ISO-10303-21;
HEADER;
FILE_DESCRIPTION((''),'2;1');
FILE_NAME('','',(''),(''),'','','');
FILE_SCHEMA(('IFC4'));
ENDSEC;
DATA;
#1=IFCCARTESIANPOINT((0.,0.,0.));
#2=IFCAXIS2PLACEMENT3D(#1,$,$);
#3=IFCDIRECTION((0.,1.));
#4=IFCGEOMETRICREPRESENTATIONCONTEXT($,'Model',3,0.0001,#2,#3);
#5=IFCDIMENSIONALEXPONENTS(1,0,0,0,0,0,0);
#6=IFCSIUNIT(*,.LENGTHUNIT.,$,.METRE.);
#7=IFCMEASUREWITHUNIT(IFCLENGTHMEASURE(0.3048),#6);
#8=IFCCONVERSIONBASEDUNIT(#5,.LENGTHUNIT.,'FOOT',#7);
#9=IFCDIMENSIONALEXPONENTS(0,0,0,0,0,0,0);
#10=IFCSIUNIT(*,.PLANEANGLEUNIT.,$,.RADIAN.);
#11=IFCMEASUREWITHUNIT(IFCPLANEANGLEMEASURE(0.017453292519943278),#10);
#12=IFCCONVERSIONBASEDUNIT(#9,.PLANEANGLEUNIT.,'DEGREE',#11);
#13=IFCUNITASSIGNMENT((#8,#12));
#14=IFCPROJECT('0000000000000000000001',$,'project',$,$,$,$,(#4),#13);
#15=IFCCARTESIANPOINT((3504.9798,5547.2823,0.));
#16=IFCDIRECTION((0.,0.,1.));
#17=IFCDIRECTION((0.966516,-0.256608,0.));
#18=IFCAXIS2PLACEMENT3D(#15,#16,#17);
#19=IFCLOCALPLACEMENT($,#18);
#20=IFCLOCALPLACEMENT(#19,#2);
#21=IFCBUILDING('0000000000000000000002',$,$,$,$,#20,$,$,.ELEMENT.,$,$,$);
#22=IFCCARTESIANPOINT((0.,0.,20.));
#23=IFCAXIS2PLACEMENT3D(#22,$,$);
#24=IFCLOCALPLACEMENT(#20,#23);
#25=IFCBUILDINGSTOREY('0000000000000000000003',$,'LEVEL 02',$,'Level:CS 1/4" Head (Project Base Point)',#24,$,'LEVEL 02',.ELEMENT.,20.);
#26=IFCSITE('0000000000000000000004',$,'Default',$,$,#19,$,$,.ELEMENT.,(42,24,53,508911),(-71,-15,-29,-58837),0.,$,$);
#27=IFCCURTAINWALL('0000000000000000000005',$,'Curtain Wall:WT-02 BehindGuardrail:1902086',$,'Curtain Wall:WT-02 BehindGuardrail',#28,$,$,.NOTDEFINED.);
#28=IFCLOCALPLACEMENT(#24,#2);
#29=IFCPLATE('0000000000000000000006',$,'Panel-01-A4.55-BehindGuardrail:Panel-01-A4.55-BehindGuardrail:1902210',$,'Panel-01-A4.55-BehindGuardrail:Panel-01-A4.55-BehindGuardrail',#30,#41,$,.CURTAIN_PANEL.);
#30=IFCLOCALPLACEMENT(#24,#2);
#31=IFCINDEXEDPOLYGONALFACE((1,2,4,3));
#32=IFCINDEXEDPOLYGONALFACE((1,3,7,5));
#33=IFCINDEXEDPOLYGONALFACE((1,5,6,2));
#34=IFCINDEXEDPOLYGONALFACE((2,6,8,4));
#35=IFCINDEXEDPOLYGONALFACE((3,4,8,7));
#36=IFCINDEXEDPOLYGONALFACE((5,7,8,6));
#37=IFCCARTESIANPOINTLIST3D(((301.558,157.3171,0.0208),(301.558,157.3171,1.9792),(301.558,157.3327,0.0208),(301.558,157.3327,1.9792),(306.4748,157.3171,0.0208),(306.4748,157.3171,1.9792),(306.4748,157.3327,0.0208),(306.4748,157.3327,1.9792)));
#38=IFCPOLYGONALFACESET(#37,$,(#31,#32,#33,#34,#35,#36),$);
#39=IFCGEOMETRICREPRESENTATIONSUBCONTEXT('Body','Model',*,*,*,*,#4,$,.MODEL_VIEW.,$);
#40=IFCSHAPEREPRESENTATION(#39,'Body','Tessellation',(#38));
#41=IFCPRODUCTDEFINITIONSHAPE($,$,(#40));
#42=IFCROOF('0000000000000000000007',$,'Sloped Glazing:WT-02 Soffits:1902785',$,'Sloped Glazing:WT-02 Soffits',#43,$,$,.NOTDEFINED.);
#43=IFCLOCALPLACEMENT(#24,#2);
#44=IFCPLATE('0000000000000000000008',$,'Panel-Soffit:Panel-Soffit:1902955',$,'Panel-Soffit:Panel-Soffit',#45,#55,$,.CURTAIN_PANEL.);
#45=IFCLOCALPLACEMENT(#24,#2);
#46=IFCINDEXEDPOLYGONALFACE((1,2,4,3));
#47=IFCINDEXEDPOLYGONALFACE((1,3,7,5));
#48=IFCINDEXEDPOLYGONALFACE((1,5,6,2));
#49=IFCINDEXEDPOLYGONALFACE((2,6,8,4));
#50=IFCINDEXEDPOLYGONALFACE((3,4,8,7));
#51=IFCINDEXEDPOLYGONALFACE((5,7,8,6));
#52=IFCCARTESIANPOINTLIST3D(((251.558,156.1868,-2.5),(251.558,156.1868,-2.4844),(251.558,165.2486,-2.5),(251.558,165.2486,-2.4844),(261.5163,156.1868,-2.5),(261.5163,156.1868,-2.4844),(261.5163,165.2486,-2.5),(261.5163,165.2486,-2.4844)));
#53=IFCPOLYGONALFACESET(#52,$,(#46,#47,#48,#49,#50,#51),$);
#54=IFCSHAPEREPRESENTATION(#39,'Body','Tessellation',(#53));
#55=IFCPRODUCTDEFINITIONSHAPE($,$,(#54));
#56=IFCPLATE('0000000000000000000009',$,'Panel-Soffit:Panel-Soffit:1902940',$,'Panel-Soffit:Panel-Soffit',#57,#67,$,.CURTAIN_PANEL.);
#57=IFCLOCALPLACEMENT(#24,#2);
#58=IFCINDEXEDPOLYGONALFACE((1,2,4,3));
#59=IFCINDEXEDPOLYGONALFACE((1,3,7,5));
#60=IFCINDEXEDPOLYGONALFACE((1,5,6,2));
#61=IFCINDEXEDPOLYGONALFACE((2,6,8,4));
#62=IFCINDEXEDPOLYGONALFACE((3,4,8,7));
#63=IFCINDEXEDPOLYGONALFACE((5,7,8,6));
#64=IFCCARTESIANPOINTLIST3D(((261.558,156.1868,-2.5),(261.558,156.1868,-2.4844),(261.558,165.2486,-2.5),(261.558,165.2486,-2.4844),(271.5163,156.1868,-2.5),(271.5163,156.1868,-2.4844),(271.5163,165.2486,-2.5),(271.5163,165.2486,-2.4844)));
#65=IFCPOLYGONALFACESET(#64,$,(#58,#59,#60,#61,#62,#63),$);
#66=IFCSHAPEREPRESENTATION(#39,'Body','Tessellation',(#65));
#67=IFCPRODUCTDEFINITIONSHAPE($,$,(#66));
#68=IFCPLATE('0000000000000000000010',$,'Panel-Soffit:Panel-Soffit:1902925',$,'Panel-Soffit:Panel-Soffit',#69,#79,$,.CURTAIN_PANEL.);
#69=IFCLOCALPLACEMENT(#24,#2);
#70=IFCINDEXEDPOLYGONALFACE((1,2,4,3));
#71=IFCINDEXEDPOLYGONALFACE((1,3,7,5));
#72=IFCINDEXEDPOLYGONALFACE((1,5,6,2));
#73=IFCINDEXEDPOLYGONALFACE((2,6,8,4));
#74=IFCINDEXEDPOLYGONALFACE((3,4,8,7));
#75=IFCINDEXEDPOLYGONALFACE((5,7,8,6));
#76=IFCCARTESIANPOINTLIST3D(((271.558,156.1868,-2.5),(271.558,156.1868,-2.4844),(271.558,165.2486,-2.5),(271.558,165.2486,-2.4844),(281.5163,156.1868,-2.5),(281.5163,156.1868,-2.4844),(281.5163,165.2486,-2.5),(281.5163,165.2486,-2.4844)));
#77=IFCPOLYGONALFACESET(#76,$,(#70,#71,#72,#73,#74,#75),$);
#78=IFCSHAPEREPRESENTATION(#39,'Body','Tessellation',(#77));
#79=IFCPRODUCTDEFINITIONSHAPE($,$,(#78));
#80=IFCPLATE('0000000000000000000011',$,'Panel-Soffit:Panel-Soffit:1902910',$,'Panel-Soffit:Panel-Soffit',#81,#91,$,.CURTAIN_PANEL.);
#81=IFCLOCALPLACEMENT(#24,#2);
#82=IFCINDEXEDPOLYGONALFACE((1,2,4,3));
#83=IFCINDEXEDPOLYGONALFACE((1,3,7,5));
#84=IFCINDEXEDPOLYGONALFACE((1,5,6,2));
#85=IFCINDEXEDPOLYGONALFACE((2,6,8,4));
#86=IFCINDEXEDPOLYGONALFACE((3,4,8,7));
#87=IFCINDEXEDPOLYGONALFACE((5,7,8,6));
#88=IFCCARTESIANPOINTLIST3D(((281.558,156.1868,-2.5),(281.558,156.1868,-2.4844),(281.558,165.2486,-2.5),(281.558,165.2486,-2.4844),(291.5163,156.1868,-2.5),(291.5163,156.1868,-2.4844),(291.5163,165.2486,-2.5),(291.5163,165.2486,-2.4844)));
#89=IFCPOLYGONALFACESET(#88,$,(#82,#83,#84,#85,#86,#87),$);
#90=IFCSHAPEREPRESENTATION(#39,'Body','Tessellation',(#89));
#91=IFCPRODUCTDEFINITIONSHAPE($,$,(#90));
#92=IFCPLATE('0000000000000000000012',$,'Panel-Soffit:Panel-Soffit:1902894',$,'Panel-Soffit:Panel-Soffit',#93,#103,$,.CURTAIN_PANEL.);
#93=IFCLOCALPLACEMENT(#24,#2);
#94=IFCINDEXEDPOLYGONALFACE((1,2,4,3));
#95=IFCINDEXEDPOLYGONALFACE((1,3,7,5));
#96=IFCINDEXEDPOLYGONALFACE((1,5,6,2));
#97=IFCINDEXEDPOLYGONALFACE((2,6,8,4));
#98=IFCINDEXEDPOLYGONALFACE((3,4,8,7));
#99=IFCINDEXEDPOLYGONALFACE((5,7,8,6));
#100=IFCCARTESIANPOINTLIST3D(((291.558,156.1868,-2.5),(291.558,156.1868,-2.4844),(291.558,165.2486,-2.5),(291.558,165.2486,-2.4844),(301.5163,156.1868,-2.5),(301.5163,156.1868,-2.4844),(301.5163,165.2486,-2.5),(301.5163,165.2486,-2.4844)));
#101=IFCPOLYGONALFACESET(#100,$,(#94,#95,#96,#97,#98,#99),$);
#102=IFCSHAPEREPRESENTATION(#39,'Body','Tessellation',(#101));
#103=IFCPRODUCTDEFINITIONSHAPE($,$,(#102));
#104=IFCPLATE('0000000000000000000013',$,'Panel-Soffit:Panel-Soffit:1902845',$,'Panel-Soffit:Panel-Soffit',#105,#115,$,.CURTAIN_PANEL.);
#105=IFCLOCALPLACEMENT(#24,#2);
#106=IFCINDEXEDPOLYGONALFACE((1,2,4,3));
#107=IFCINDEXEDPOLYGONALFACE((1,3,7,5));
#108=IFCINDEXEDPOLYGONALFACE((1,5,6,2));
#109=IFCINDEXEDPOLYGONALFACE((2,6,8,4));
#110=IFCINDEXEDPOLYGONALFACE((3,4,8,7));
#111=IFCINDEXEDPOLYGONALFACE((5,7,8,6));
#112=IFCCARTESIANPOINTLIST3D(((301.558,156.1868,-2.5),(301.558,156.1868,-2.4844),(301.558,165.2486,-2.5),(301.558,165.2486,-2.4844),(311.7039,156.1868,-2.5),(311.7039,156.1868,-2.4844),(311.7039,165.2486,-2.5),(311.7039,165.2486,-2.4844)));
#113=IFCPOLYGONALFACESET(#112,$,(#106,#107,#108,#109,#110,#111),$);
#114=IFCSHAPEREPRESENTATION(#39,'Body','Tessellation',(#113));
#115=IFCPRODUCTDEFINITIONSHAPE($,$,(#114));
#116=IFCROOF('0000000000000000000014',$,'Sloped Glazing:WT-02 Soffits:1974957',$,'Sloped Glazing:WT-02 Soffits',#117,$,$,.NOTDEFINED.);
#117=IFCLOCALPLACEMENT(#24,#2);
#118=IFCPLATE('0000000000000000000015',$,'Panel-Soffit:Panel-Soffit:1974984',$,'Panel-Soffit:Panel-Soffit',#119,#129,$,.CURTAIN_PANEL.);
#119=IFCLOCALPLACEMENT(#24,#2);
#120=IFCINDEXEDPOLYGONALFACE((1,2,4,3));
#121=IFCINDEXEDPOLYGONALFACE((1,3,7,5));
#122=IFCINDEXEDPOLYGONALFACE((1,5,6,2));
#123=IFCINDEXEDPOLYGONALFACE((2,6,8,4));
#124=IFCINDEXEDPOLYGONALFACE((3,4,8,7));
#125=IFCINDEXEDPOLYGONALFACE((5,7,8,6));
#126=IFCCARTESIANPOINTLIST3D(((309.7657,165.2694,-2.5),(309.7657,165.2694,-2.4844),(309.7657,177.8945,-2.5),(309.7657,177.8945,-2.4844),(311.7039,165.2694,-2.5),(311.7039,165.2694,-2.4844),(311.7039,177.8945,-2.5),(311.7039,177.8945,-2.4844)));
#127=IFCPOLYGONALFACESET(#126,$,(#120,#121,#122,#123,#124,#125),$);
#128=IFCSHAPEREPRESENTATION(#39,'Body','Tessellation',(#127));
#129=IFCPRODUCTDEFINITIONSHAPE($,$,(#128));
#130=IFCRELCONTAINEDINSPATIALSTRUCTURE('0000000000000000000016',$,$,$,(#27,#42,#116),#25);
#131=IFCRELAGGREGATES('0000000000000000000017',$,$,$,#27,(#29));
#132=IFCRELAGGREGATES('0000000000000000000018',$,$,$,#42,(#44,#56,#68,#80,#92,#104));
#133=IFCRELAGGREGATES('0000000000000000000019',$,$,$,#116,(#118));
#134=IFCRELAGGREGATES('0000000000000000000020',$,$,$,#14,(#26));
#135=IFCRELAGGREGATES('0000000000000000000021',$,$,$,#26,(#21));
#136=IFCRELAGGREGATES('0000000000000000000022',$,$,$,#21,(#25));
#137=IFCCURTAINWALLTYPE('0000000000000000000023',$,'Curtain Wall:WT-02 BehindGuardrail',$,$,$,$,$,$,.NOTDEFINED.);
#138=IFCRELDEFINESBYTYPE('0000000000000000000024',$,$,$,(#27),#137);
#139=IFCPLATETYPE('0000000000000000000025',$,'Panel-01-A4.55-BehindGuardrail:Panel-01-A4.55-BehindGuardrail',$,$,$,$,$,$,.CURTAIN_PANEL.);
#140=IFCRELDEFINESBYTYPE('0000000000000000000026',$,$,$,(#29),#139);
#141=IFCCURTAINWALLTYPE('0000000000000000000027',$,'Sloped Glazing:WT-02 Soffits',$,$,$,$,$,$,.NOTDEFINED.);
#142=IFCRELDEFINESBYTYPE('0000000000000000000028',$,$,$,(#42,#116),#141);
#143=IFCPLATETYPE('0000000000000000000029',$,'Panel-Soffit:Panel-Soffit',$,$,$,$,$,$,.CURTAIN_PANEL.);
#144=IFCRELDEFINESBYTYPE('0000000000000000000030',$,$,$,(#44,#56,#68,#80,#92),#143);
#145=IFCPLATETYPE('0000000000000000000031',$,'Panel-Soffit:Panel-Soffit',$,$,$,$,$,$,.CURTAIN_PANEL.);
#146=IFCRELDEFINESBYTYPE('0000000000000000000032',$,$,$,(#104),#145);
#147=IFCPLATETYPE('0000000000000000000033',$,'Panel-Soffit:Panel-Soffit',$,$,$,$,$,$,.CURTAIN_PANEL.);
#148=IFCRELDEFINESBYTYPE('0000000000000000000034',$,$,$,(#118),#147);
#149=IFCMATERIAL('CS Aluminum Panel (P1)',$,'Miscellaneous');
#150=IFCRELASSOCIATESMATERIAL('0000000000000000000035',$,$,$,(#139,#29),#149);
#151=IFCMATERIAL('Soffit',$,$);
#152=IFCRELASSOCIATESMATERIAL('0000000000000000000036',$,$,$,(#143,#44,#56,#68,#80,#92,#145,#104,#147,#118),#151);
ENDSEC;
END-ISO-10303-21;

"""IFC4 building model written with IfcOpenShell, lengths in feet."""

from ifc_helpers import new_model, entity, si_unit, converted_unit, direction, frame, origin, place, context, subcontext, project, spatial, indexed_curve, outline, extrude, source, transform, mapped, material, type_object, type_shapes, element, aggregate, save


model = new_model("IFC4")

# Units and contexts
model_context = context("Model", 3, precision=0.0001, world=origin(), true_north=direction((0.0, 1.0)))
body_context = subcontext(model_context, "Body", "Model", "MODEL_VIEW")
ifc_project = project(units=[converted_unit("LENGTHUNIT", "FOOT", entity("IfcLengthMeasure", 0.3048), si_unit("LENGTHUNIT", "METRE"), dimensions=[1, 0, 0, 0, 0, 0, 0]), converted_unit("PLANEANGLEUNIT", "DEGREE", entity("IfcPlaneAngleMeasure", 0.017453292519943278), si_unit("PLANEANGLEUNIT", "RADIAN"), dimensions=[0, 0, 0, 0, 0, 0, 0])], contexts=[model_context])

# Site, building, storey
site_placement = place(None, frame((3504.9798, 5547.2823, 0.0), z_axis=(0.0, 0.0, 1.0), x_axis=(0.966516, -0.256608, 0.0)))
site = spatial("IfcSite", under=ifc_project, at=site_placement, Name="Default", CompositionType="ELEMENT", RefLatitude=(42, 24, 53, 508911), RefLongitude=(-71, -15, -29, -58837), RefElevation=0.0)
building_placement = place(site_placement, origin())
building = spatial("IfcBuilding", under=site, at=building_placement, CompositionType="ELEMENT")
storey_placement = place(building_placement, frame((0.0, 0.0, 20.0)))
storey = spatial("IfcBuildingStorey", under=building, at=storey_placement, Name="LEVEL 02", ObjectType="Level:CS 1/4\" Head (Project Base Point)", LongName="LEVEL 02", CompositionType="ELEMENT", Elevation=20.0)

# Curtain wall, plate
ifc_material_1 = material(Name="CS Aluminum Panel (P1)", Category="Miscellaneous")
curtain_wall_type_1 = type_object("IfcCurtainWallType", Name="Curtain Wall:WT-02 BehindGuardrail", PredefinedType="NOTDEFINED")
curtain_wall_1_placement = place(storey_placement, frame((0.0, 0.0, -20.0)))
curtain_wall_1 = element("IfcCurtainWall", 1, at=curtain_wall_1_placement, inside=storey, type_object=curtain_wall_type_1, Name="Curtain Wall:WT-02 BehindGuardrail:1902086", ObjectType="Curtain Wall:WT-02 BehindGuardrail", PredefinedType="NOTDEFINED")
plate_type_1 = type_object("IfcPlateType", Name="Panel-01-A4.55-BehindGuardrail:Panel-01-A4.55-BehindGuardrail", PredefinedType="CURTAIN_PANEL", material=ifc_material_1)
shared_shape_1 = source(origin(), body_context, "Body", "SweptSolid", [
    extrude(outline(indexed_curve([(-0.0078, -2.4584), (0.0078, -2.4584), (0.0078, 2.4584), (-0.0078, 2.4584), (-0.0078, -2.4584)], self_intersect=False)), frame((2.4584, 0.0078, 0.0), z_axis=(0.0, 0.0, 1.0), x_axis=(0.0, -1.0, 0.0)), (0.0, 0.0, 1.0), 1.9583),
])
type_shapes(plate_type_1, [shared_shape_1])
plate_1_placement = place(curtain_wall_1_placement, frame((301.558, 157.3171, 20.0208)))
plate_1 = element("IfcPlate", 2, at=plate_1_placement, type_object=plate_type_1, material=ifc_material_1, Name="Panel-01-A4.55-BehindGuardrail:Panel-01-A4.55-BehindGuardrail:1902210", ObjectType="Panel-01-A4.55-BehindGuardrail:Panel-01-A4.55-BehindGuardrail", PredefinedType="CURTAIN_PANEL", context=body_context, shape_type="MappedRepresentation", body=[
    mapped(shared_shape_1, transform((0.0, 0.0, 0.0), scale=1.0)),
])
aggregate(curtain_wall_1, [plate_1])

# Roof, plates
curtain_wall_type_2 = type_object("IfcCurtainWallType", Name="Sloped Glazing:WT-02 Soffits", PredefinedType="NOTDEFINED")
roof_1_placement = place(storey_placement, frame((0.0, 0.0, -20.0)))
roof_1 = element("IfcRoof", 3, at=roof_1_placement, inside=storey, type_object=curtain_wall_type_2, Name="Sloped Glazing:WT-02 Soffits:1902785", ObjectType="Sloped Glazing:WT-02 Soffits", PredefinedType="NOTDEFINED")
ifc_material_2 = material(Name="Soffit")
plate_type_2 = type_object("IfcPlateType", Name="Panel-Soffit:Panel-Soffit", PredefinedType="CURTAIN_PANEL", material=ifc_material_2)
shared_shape_2 = source(origin(), body_context, "Body", "SweptSolid", [
    extrude(outline(indexed_curve([(-0.0078, -4.9792), (0.0078, -4.9792), (0.0078, 4.9792), (-0.0078, 4.9792), (-0.0078, -4.9792)], self_intersect=False)), frame((4.9792, 0.0078, 0.0), z_axis=(0.0, 0.0, 1.0), x_axis=(0.0, -1.0, 0.0)), (0.0, 0.0, 1.0), 9.0617),
])
type_shapes(plate_type_2, [shared_shape_2])
plate_2_placement = place(roof_1_placement, frame((251.558, 156.1868, 17.5156), z_axis=(0.0, 1.0, 0.0), x_axis=(1.0, 0.0, 0.0)))
plate_2 = element("IfcPlate", 4, at=plate_2_placement, type_object=plate_type_2, material=ifc_material_2, Name="Panel-Soffit:Panel-Soffit:1902955", ObjectType="Panel-Soffit:Panel-Soffit", PredefinedType="CURTAIN_PANEL", context=body_context, shape_type="MappedRepresentation", body=[
    mapped(shared_shape_2, transform((0.0, 0.0, 0.0), scale=1.0)),
])
plate_3_placement = place(roof_1_placement, frame((261.558, 156.1868, 17.5156), z_axis=(0.0, 1.0, 0.0), x_axis=(1.0, 0.0, 0.0)))
plate_3 = element("IfcPlate", 5, at=plate_3_placement, type_object=plate_type_2, material=ifc_material_2, Name="Panel-Soffit:Panel-Soffit:1902940", ObjectType="Panel-Soffit:Panel-Soffit", PredefinedType="CURTAIN_PANEL", context=body_context, shape_type="MappedRepresentation", body=[
    mapped(shared_shape_2, transform((0.0, 0.0, 0.0), scale=1.0)),
])
plate_4_placement = place(roof_1_placement, frame((271.558, 156.1868, 17.5156), z_axis=(0.0, 1.0, 0.0), x_axis=(1.0, 0.0, 0.0)))
plate_4 = element("IfcPlate", 6, at=plate_4_placement, type_object=plate_type_2, material=ifc_material_2, Name="Panel-Soffit:Panel-Soffit:1902925", ObjectType="Panel-Soffit:Panel-Soffit", PredefinedType="CURTAIN_PANEL", context=body_context, shape_type="MappedRepresentation", body=[
    mapped(shared_shape_2, transform((0.0, 0.0, 0.0), scale=1.0)),
])
plate_5_placement = place(roof_1_placement, frame((281.558, 156.1868, 17.5156), z_axis=(0.0, 1.0, 0.0), x_axis=(1.0, 0.0, 0.0)))
plate_5 = element("IfcPlate", 7, at=plate_5_placement, type_object=plate_type_2, material=ifc_material_2, Name="Panel-Soffit:Panel-Soffit:1902910", ObjectType="Panel-Soffit:Panel-Soffit", PredefinedType="CURTAIN_PANEL", context=body_context, shape_type="MappedRepresentation", body=[
    mapped(shared_shape_2, transform((0.0, 0.0, 0.0), scale=1.0)),
])
plate_6_placement = place(roof_1_placement, frame((291.558, 156.1868, 17.5156), z_axis=(0.0, 1.0, 0.0), x_axis=(1.0, 0.0, 0.0)))
plate_6 = element("IfcPlate", 8, at=plate_6_placement, type_object=plate_type_2, material=ifc_material_2, Name="Panel-Soffit:Panel-Soffit:1902894", ObjectType="Panel-Soffit:Panel-Soffit", PredefinedType="CURTAIN_PANEL", context=body_context, shape_type="MappedRepresentation", body=[
    mapped(shared_shape_2, transform((0.0, 0.0, 0.0), scale=1.0)),
])
plate_type_3 = type_object("IfcPlateType", Name="Panel-Soffit:Panel-Soffit", PredefinedType="CURTAIN_PANEL", material=ifc_material_2)
shared_shape_3 = source(origin(), body_context, "Body", "SweptSolid", [
    extrude(outline(indexed_curve([(-0.0078, -5.073), (0.0078, -5.073), (0.0078, 5.073), (-0.0078, 5.073), (-0.0078, -5.073)], self_intersect=False)), frame((5.073, 0.0078, 0.0), z_axis=(0.0, 0.0, 1.0), x_axis=(0.0, -1.0, 0.0)), (0.0, 0.0, 1.0), 9.0617),
])
type_shapes(plate_type_3, [shared_shape_3])
plate_7_placement = place(roof_1_placement, frame((301.558, 156.1868, 17.5156), z_axis=(0.0, 1.0, 0.0), x_axis=(1.0, 0.0, 0.0)))
plate_7 = element("IfcPlate", 9, at=plate_7_placement, type_object=plate_type_3, material=ifc_material_2, Name="Panel-Soffit:Panel-Soffit:1902845", ObjectType="Panel-Soffit:Panel-Soffit", PredefinedType="CURTAIN_PANEL", context=body_context, shape_type="MappedRepresentation", body=[
    mapped(shared_shape_3, transform((0.0, 0.0, 0.0), scale=1.0)),
])
aggregate(roof_1, [plate_2, plate_3, plate_4, plate_5, plate_6, plate_7])

# Roof, plate
roof_2_placement = place(storey_placement, frame((0.0, 0.0, -20.0)))
roof_2 = element("IfcRoof", 10, at=roof_2_placement, inside=storey, type_object=curtain_wall_type_2, Name="Sloped Glazing:WT-02 Soffits:1974957", ObjectType="Sloped Glazing:WT-02 Soffits", PredefinedType="NOTDEFINED")
plate_type_4 = type_object("IfcPlateType", Name="Panel-Soffit:Panel-Soffit", PredefinedType="CURTAIN_PANEL", material=ifc_material_2)
shared_shape_4 = source(origin(), body_context, "Body", "SweptSolid", [
    extrude(outline(indexed_curve([(-0.0078, -0.9691), (0.0078, -0.9691), (0.0078, 0.9691), (-0.0078, 0.9691), (-0.0078, -0.9691)], self_intersect=False)), frame((0.9691, 0.0078, 0.0), z_axis=(0.0, 0.0, 1.0), x_axis=(0.0, -1.0, 0.0)), (0.0, 0.0, 1.0), 12.6251),
])
type_shapes(plate_type_4, [shared_shape_4])
plate_8_placement = place(roof_2_placement, frame((309.7657, 165.2694, 17.5156), z_axis=(0.0, 1.0, 0.0), x_axis=(1.0, 0.0, 0.0)))
plate_8 = element("IfcPlate", 11, at=plate_8_placement, type_object=plate_type_4, material=ifc_material_2, Name="Panel-Soffit:Panel-Soffit:1974984", ObjectType="Panel-Soffit:Panel-Soffit", PredefinedType="CURTAIN_PANEL", context=body_context, shape_type="MappedRepresentation", body=[
    mapped(shared_shape_4, transform((0.0, 0.0, 0.0), scale=1.0)),
])
aggregate(roof_2, [plate_8])

save(model, "model.ifc")
